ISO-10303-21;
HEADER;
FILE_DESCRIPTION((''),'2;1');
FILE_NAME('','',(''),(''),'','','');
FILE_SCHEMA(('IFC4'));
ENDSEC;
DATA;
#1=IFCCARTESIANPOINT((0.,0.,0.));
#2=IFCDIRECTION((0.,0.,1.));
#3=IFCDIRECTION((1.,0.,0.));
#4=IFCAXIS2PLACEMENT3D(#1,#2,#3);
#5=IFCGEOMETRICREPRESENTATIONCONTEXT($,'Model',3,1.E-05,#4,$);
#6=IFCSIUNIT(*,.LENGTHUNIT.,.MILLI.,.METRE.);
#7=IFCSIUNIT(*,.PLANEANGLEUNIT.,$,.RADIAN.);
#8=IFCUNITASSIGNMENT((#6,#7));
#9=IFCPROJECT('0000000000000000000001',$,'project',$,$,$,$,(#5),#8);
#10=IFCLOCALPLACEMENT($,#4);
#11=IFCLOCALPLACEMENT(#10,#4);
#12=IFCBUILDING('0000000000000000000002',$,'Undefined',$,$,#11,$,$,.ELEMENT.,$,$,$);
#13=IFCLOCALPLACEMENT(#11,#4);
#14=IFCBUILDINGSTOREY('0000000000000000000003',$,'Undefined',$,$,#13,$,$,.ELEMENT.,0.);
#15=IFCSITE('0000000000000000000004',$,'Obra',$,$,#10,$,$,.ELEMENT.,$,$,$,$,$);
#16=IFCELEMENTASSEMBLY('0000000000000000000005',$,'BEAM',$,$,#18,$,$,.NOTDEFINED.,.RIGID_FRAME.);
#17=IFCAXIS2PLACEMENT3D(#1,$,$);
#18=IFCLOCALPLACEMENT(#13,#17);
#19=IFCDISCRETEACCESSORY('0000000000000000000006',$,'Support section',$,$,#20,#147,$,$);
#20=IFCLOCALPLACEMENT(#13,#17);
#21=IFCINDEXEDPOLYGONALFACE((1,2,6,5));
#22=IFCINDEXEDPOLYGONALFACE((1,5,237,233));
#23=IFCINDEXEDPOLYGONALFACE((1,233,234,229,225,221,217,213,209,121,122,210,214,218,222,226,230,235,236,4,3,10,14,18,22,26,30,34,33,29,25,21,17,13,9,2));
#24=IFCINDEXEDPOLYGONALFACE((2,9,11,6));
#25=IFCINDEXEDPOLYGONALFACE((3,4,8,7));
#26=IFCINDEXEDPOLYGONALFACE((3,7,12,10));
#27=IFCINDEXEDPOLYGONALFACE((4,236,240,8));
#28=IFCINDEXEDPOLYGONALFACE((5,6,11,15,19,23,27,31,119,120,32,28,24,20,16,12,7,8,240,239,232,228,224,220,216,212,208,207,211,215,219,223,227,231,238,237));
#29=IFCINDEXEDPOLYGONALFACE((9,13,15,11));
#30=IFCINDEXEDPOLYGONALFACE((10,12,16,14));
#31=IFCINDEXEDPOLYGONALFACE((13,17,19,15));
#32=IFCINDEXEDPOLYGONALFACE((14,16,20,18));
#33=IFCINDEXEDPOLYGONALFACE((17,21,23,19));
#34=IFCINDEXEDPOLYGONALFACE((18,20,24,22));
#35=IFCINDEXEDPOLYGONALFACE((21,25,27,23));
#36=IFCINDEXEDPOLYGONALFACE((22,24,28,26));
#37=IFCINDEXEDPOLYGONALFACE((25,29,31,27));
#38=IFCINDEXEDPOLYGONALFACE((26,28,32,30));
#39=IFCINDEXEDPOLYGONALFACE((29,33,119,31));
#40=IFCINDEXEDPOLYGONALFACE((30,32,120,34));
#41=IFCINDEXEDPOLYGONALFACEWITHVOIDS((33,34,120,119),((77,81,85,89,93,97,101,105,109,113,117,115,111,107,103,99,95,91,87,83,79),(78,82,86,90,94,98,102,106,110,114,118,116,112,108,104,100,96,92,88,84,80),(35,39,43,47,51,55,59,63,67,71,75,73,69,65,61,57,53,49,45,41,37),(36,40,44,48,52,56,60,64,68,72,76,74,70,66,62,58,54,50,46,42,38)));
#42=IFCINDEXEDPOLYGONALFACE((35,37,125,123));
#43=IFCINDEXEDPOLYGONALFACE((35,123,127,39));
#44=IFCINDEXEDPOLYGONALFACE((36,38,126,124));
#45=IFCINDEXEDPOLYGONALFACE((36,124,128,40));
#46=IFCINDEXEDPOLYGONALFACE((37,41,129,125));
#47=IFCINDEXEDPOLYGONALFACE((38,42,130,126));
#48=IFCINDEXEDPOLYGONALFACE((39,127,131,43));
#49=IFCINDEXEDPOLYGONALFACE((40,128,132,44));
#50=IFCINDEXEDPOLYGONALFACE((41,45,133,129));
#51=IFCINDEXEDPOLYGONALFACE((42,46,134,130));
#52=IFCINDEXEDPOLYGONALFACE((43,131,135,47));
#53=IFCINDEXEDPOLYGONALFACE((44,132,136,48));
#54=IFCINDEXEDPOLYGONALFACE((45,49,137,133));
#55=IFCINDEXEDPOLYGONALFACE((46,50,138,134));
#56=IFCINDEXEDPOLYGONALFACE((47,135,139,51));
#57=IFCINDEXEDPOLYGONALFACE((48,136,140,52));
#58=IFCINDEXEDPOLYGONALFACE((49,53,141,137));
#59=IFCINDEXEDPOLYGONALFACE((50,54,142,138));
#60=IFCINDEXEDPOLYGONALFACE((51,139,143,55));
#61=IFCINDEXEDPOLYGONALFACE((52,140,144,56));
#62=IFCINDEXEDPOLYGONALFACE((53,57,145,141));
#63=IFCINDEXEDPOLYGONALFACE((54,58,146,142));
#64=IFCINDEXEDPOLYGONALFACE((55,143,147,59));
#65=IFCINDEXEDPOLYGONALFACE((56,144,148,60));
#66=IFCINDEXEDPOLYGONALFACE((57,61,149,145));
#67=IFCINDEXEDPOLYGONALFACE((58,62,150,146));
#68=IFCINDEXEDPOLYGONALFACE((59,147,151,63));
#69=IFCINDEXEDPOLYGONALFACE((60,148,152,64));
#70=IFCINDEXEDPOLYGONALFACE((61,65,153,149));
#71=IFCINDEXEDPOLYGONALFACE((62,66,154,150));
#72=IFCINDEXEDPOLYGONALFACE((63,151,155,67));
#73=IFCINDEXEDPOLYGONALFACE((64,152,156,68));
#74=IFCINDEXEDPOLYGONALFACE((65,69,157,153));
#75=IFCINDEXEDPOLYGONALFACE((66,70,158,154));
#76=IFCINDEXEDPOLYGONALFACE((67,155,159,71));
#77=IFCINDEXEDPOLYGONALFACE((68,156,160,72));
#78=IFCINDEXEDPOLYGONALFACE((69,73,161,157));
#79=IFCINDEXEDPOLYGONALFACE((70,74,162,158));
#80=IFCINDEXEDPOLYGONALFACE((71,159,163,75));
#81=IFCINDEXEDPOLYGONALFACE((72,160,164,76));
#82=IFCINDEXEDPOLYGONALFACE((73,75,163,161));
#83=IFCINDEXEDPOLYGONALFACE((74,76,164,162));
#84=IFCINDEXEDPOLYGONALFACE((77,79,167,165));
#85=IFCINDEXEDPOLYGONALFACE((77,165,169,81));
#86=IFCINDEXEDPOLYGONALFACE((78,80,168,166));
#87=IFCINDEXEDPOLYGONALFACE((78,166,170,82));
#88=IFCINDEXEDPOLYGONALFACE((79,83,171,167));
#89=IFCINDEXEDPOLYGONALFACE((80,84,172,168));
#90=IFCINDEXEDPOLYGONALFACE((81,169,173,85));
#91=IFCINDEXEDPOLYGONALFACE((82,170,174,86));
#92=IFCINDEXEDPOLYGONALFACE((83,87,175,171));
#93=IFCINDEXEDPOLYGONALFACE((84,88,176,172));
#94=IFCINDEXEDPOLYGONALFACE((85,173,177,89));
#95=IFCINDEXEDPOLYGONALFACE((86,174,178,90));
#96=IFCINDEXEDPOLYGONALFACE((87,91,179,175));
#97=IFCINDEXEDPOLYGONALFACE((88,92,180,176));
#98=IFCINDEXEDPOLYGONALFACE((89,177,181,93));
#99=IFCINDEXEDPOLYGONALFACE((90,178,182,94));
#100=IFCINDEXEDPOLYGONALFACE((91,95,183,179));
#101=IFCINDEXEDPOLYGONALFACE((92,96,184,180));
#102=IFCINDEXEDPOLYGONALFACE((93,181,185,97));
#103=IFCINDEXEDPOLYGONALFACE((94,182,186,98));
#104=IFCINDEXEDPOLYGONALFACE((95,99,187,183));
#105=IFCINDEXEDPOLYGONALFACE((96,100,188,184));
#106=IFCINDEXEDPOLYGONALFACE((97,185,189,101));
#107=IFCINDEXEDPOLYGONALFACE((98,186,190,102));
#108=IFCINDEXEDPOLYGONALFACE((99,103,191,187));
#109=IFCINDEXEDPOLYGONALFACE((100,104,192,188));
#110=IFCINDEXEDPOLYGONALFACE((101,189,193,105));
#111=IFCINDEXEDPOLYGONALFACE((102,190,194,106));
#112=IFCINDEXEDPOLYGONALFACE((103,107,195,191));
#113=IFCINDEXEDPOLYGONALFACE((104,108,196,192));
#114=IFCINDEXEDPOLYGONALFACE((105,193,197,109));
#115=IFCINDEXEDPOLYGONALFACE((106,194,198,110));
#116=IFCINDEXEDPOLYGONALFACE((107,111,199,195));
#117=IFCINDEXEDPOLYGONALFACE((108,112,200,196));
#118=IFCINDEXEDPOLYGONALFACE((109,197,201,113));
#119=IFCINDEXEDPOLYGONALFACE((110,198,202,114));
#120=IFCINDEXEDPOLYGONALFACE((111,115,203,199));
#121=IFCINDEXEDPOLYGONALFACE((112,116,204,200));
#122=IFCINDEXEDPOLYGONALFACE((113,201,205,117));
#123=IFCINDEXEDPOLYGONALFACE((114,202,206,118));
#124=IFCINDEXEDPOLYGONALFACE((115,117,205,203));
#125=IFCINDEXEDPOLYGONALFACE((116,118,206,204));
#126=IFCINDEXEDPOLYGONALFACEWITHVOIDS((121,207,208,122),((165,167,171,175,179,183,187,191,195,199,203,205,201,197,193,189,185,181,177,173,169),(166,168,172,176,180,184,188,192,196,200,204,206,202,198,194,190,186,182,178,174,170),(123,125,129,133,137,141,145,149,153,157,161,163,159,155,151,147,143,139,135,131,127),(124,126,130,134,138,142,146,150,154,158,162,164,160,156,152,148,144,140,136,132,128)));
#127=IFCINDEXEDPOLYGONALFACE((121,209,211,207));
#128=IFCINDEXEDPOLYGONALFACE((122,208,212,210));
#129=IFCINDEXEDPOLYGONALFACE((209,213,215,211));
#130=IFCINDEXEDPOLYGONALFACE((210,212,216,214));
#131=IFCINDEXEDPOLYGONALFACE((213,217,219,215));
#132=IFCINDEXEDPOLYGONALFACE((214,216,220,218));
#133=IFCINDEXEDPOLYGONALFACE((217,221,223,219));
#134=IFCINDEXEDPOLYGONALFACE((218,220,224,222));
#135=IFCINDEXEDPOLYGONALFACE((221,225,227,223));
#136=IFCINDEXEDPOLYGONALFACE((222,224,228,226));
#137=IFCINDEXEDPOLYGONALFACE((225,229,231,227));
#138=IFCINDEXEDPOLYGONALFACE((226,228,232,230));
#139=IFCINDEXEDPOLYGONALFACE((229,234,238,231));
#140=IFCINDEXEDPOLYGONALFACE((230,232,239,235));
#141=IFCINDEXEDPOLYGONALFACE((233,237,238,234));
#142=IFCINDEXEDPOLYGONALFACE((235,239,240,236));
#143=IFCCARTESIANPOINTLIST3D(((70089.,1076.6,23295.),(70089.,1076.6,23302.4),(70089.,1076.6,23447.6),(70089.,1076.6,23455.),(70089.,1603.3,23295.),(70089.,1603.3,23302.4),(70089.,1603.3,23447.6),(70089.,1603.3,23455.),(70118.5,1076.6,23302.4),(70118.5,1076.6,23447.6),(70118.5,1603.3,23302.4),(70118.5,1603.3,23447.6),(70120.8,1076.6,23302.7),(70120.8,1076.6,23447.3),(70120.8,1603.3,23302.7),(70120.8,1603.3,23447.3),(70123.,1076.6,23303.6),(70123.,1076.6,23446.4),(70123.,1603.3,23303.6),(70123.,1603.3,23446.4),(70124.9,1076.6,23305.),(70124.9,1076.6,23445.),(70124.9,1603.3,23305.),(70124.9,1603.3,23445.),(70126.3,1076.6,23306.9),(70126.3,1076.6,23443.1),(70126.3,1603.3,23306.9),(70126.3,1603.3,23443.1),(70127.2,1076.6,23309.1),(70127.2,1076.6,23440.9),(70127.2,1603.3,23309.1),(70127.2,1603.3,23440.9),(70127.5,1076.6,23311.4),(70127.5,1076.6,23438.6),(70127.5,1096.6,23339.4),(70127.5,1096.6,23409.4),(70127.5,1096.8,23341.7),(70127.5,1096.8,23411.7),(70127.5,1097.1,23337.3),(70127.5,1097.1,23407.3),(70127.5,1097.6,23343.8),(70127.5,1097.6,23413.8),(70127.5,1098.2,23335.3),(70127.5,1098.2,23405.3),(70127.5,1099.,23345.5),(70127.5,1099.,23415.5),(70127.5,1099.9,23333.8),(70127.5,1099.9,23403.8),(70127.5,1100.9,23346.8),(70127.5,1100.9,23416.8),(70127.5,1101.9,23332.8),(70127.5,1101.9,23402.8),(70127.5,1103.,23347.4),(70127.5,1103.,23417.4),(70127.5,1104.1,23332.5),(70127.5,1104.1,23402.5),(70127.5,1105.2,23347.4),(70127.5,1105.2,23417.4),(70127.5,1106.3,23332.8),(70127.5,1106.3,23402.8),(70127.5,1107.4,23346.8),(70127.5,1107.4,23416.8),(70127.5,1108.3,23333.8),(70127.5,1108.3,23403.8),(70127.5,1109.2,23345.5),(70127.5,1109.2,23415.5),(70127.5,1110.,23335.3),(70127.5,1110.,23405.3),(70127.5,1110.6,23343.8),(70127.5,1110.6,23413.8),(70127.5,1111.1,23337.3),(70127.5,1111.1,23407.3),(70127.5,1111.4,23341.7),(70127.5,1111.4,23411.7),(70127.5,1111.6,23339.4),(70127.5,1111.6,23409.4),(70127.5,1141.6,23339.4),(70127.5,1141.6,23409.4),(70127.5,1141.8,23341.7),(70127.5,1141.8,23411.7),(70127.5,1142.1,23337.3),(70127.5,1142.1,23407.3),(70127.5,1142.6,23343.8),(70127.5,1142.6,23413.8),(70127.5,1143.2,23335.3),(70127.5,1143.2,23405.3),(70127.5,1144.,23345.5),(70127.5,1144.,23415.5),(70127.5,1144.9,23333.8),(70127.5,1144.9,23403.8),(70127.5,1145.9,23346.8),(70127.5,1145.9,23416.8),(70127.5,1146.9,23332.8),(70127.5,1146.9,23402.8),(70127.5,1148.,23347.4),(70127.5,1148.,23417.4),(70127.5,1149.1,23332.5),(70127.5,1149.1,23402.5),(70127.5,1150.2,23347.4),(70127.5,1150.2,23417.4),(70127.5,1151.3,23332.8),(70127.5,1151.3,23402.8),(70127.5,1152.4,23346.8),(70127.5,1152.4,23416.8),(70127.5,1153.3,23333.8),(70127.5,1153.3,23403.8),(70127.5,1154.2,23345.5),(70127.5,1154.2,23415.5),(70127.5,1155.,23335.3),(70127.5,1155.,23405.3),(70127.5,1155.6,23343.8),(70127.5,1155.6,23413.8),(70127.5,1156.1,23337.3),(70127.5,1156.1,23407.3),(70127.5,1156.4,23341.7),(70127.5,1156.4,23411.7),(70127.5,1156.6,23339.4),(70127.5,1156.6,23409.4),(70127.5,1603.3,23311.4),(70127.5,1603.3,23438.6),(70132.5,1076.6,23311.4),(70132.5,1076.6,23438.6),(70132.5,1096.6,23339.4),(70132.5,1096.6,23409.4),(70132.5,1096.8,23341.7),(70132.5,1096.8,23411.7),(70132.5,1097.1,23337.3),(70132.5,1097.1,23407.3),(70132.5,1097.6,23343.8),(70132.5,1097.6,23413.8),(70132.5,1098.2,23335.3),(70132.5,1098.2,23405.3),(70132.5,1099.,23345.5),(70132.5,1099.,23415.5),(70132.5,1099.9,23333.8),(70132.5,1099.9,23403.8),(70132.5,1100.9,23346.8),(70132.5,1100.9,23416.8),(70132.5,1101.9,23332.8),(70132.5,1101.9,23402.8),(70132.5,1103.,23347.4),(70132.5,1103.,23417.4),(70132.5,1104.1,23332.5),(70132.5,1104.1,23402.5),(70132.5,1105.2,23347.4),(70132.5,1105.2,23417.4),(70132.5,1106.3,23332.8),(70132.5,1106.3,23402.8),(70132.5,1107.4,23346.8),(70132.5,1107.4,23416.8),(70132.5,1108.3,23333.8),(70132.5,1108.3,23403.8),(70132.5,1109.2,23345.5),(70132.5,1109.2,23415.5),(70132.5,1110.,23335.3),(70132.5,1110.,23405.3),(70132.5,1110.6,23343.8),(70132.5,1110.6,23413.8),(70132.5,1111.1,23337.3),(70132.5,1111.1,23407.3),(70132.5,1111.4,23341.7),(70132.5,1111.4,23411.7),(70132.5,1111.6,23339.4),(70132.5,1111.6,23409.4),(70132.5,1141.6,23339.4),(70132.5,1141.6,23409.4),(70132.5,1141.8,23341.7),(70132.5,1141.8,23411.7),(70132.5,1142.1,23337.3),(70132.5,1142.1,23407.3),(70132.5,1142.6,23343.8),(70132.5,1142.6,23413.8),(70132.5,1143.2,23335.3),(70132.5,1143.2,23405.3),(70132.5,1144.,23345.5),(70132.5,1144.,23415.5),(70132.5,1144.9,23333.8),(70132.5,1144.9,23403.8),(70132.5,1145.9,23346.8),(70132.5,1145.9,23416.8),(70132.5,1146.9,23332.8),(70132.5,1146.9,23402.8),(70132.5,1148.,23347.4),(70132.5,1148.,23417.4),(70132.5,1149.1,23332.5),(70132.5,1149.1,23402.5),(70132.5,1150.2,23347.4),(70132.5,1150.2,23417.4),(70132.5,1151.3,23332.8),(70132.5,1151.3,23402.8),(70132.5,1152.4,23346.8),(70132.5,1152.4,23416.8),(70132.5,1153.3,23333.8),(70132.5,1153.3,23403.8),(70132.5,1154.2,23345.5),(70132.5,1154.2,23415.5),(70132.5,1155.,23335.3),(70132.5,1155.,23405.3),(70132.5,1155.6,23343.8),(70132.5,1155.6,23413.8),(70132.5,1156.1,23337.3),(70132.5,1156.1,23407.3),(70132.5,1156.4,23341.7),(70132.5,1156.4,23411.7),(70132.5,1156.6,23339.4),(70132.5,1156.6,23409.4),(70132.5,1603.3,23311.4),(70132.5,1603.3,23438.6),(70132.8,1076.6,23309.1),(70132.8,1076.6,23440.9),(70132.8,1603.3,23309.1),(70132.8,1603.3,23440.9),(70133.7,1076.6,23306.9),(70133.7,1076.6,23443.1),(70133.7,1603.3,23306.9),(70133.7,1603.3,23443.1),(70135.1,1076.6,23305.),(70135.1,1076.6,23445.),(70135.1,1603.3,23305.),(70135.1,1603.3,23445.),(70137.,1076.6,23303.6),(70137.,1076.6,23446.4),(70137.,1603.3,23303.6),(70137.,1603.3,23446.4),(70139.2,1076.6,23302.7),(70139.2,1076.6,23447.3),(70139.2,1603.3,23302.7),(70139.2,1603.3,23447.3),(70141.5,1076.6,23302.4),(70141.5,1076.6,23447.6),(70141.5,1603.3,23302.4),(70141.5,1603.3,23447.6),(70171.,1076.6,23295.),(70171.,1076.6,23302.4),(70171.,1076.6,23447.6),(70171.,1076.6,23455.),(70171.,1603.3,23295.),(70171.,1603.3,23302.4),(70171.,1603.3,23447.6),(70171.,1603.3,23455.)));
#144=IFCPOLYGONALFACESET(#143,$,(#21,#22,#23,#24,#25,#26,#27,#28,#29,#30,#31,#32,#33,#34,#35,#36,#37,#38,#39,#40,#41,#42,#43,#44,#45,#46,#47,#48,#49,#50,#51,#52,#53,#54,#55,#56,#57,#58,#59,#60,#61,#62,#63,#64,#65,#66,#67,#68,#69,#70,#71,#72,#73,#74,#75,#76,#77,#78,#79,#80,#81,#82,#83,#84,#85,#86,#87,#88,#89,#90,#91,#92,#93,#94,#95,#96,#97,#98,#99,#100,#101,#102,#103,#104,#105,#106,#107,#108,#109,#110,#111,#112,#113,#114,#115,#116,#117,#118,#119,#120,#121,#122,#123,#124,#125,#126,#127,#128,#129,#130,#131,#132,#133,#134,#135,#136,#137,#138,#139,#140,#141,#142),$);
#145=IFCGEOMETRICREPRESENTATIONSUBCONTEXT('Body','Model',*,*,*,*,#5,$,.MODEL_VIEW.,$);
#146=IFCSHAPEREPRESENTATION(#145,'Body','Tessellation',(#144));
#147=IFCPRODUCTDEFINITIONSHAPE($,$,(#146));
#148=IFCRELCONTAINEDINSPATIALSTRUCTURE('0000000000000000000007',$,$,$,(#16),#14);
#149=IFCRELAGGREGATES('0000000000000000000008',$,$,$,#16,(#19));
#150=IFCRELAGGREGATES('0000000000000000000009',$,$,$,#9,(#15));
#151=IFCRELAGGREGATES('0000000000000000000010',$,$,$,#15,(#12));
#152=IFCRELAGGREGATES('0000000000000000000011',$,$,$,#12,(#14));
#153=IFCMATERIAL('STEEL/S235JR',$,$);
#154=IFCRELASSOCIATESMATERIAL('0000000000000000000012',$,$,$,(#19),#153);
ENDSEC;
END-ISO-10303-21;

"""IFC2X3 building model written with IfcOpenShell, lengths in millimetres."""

from ifc_helpers import new_model, si_unit, frame, origin_with_axes, origin_2d_with_axis, place, context, subcontext, project, spatial, circle, i_section, extrude, clip, halfspace, source, transform, mapped, material, element, aggregate, save


model = new_model("IFC2X3")

# Units and contexts
model_context = context("Model", 3, precision=1e-05, world=origin_with_axes())
body_context = subcontext(model_context, "Body", "Model", "MODEL_VIEW")
ifc_project = project(units=[si_unit("LENGTHUNIT", "METRE", prefix="MILLI"), si_unit("PLANEANGLEUNIT", "RADIAN")], contexts=[model_context])

# Site, building, storey
site_placement = place(None, origin_with_axes())
site = spatial("IfcSite", under=ifc_project, at=site_placement, Name="Obra", CompositionType="ELEMENT")
building_placement = place(site_placement, origin_with_axes())
building = spatial("IfcBuilding", under=site, at=building_placement, Name="Undefined", CompositionType="ELEMENT")
storey_placement = place(building_placement, origin_with_axes())
storey = spatial("IfcBuildingStorey", under=building, at=storey_placement, Name="Undefined", CompositionType="ELEMENT", Elevation=0.0)

# Shared definitions
ifc_material_1 = material(Name="STEEL/S235JR")

# Element assembly
assembly_1_placement = place(storey_placement, origin_with_axes())
assembly_1 = element("IfcElementAssembly", 1, at=assembly_1_placement, inside=storey, Name="BEAM", AssemblyPlace="NOTDEFINED", PredefinedType="RIGID_FRAME")

# Discrete accessory, opening
shared_shape_1 = source(origin_with_axes(), body_context, "Body", "SweptSolid", [
    extrude(circle(Radius=7.5, at=origin_2d_with_axis()), frame((0.0, -2.6, 0.0), z_axis=(0.0, 1.0, 0.0), x_axis=(1.0, 0.0, 0.0)), (0.0, 0.0, 1.0), 5.2),
])
discrete_accessory_1_placement = place(assembly_1_placement, frame((70130.0, 1086.6, 23375.0), z_axis=(0.0, 0.0, 1.0), x_axis=(0.0, 1.0, 0.0)))
discrete_accessory_1 = element("IfcDiscreteAccessory", 2, at=discrete_accessory_1_placement, material=ifc_material_1, Name="Support section", context=body_context, shape_type="Clipping", body=[
    clip(extrude(i_section(OverallWidth=82.0, OverallDepth=160.0, WebThickness=5.0, FlangeThickness=7.4, FilletRadius=9.0, at=origin_2d_with_axis()), frame((516.7, 0.0, 0.0), z_axis=(-1.0, 0.0, 0.0), x_axis=(0.0, -1.0, 0.0)), (0.0, 0.0, 1.0), 526.7), halfspace(frame((-10.0, 0.0, -180.0), z_axis=(1.0, 0.0, 0.0), x_axis=(0.0, -1.0, 0.0)), True)),
])
opening_1_placement = place(assembly_1_placement, frame((70130.0, 1126.6, 23410.0), z_axis=(0.0, 1.0, 0.0), x_axis=(0.0, 0.0, -1.0)))
element("IfcOpeningElement", 3, at=opening_1_placement, cuts=discrete_accessory_1, ObjectType="Opening", context=body_context, shape_type="MappedRepresentation", body=[
    mapped(shared_shape_1, transform((0.0, 0.0, -22.5))),
    mapped(shared_shape_1, transform((70.0, 0.0, -22.5))),
    mapped(shared_shape_1, transform((0.0, 0.0, 22.5))),
    mapped(shared_shape_1, transform((70.0, 0.0, 22.5))),
])
aggregate(assembly_1, [discrete_accessory_1])

save(model, "model.ifc")
